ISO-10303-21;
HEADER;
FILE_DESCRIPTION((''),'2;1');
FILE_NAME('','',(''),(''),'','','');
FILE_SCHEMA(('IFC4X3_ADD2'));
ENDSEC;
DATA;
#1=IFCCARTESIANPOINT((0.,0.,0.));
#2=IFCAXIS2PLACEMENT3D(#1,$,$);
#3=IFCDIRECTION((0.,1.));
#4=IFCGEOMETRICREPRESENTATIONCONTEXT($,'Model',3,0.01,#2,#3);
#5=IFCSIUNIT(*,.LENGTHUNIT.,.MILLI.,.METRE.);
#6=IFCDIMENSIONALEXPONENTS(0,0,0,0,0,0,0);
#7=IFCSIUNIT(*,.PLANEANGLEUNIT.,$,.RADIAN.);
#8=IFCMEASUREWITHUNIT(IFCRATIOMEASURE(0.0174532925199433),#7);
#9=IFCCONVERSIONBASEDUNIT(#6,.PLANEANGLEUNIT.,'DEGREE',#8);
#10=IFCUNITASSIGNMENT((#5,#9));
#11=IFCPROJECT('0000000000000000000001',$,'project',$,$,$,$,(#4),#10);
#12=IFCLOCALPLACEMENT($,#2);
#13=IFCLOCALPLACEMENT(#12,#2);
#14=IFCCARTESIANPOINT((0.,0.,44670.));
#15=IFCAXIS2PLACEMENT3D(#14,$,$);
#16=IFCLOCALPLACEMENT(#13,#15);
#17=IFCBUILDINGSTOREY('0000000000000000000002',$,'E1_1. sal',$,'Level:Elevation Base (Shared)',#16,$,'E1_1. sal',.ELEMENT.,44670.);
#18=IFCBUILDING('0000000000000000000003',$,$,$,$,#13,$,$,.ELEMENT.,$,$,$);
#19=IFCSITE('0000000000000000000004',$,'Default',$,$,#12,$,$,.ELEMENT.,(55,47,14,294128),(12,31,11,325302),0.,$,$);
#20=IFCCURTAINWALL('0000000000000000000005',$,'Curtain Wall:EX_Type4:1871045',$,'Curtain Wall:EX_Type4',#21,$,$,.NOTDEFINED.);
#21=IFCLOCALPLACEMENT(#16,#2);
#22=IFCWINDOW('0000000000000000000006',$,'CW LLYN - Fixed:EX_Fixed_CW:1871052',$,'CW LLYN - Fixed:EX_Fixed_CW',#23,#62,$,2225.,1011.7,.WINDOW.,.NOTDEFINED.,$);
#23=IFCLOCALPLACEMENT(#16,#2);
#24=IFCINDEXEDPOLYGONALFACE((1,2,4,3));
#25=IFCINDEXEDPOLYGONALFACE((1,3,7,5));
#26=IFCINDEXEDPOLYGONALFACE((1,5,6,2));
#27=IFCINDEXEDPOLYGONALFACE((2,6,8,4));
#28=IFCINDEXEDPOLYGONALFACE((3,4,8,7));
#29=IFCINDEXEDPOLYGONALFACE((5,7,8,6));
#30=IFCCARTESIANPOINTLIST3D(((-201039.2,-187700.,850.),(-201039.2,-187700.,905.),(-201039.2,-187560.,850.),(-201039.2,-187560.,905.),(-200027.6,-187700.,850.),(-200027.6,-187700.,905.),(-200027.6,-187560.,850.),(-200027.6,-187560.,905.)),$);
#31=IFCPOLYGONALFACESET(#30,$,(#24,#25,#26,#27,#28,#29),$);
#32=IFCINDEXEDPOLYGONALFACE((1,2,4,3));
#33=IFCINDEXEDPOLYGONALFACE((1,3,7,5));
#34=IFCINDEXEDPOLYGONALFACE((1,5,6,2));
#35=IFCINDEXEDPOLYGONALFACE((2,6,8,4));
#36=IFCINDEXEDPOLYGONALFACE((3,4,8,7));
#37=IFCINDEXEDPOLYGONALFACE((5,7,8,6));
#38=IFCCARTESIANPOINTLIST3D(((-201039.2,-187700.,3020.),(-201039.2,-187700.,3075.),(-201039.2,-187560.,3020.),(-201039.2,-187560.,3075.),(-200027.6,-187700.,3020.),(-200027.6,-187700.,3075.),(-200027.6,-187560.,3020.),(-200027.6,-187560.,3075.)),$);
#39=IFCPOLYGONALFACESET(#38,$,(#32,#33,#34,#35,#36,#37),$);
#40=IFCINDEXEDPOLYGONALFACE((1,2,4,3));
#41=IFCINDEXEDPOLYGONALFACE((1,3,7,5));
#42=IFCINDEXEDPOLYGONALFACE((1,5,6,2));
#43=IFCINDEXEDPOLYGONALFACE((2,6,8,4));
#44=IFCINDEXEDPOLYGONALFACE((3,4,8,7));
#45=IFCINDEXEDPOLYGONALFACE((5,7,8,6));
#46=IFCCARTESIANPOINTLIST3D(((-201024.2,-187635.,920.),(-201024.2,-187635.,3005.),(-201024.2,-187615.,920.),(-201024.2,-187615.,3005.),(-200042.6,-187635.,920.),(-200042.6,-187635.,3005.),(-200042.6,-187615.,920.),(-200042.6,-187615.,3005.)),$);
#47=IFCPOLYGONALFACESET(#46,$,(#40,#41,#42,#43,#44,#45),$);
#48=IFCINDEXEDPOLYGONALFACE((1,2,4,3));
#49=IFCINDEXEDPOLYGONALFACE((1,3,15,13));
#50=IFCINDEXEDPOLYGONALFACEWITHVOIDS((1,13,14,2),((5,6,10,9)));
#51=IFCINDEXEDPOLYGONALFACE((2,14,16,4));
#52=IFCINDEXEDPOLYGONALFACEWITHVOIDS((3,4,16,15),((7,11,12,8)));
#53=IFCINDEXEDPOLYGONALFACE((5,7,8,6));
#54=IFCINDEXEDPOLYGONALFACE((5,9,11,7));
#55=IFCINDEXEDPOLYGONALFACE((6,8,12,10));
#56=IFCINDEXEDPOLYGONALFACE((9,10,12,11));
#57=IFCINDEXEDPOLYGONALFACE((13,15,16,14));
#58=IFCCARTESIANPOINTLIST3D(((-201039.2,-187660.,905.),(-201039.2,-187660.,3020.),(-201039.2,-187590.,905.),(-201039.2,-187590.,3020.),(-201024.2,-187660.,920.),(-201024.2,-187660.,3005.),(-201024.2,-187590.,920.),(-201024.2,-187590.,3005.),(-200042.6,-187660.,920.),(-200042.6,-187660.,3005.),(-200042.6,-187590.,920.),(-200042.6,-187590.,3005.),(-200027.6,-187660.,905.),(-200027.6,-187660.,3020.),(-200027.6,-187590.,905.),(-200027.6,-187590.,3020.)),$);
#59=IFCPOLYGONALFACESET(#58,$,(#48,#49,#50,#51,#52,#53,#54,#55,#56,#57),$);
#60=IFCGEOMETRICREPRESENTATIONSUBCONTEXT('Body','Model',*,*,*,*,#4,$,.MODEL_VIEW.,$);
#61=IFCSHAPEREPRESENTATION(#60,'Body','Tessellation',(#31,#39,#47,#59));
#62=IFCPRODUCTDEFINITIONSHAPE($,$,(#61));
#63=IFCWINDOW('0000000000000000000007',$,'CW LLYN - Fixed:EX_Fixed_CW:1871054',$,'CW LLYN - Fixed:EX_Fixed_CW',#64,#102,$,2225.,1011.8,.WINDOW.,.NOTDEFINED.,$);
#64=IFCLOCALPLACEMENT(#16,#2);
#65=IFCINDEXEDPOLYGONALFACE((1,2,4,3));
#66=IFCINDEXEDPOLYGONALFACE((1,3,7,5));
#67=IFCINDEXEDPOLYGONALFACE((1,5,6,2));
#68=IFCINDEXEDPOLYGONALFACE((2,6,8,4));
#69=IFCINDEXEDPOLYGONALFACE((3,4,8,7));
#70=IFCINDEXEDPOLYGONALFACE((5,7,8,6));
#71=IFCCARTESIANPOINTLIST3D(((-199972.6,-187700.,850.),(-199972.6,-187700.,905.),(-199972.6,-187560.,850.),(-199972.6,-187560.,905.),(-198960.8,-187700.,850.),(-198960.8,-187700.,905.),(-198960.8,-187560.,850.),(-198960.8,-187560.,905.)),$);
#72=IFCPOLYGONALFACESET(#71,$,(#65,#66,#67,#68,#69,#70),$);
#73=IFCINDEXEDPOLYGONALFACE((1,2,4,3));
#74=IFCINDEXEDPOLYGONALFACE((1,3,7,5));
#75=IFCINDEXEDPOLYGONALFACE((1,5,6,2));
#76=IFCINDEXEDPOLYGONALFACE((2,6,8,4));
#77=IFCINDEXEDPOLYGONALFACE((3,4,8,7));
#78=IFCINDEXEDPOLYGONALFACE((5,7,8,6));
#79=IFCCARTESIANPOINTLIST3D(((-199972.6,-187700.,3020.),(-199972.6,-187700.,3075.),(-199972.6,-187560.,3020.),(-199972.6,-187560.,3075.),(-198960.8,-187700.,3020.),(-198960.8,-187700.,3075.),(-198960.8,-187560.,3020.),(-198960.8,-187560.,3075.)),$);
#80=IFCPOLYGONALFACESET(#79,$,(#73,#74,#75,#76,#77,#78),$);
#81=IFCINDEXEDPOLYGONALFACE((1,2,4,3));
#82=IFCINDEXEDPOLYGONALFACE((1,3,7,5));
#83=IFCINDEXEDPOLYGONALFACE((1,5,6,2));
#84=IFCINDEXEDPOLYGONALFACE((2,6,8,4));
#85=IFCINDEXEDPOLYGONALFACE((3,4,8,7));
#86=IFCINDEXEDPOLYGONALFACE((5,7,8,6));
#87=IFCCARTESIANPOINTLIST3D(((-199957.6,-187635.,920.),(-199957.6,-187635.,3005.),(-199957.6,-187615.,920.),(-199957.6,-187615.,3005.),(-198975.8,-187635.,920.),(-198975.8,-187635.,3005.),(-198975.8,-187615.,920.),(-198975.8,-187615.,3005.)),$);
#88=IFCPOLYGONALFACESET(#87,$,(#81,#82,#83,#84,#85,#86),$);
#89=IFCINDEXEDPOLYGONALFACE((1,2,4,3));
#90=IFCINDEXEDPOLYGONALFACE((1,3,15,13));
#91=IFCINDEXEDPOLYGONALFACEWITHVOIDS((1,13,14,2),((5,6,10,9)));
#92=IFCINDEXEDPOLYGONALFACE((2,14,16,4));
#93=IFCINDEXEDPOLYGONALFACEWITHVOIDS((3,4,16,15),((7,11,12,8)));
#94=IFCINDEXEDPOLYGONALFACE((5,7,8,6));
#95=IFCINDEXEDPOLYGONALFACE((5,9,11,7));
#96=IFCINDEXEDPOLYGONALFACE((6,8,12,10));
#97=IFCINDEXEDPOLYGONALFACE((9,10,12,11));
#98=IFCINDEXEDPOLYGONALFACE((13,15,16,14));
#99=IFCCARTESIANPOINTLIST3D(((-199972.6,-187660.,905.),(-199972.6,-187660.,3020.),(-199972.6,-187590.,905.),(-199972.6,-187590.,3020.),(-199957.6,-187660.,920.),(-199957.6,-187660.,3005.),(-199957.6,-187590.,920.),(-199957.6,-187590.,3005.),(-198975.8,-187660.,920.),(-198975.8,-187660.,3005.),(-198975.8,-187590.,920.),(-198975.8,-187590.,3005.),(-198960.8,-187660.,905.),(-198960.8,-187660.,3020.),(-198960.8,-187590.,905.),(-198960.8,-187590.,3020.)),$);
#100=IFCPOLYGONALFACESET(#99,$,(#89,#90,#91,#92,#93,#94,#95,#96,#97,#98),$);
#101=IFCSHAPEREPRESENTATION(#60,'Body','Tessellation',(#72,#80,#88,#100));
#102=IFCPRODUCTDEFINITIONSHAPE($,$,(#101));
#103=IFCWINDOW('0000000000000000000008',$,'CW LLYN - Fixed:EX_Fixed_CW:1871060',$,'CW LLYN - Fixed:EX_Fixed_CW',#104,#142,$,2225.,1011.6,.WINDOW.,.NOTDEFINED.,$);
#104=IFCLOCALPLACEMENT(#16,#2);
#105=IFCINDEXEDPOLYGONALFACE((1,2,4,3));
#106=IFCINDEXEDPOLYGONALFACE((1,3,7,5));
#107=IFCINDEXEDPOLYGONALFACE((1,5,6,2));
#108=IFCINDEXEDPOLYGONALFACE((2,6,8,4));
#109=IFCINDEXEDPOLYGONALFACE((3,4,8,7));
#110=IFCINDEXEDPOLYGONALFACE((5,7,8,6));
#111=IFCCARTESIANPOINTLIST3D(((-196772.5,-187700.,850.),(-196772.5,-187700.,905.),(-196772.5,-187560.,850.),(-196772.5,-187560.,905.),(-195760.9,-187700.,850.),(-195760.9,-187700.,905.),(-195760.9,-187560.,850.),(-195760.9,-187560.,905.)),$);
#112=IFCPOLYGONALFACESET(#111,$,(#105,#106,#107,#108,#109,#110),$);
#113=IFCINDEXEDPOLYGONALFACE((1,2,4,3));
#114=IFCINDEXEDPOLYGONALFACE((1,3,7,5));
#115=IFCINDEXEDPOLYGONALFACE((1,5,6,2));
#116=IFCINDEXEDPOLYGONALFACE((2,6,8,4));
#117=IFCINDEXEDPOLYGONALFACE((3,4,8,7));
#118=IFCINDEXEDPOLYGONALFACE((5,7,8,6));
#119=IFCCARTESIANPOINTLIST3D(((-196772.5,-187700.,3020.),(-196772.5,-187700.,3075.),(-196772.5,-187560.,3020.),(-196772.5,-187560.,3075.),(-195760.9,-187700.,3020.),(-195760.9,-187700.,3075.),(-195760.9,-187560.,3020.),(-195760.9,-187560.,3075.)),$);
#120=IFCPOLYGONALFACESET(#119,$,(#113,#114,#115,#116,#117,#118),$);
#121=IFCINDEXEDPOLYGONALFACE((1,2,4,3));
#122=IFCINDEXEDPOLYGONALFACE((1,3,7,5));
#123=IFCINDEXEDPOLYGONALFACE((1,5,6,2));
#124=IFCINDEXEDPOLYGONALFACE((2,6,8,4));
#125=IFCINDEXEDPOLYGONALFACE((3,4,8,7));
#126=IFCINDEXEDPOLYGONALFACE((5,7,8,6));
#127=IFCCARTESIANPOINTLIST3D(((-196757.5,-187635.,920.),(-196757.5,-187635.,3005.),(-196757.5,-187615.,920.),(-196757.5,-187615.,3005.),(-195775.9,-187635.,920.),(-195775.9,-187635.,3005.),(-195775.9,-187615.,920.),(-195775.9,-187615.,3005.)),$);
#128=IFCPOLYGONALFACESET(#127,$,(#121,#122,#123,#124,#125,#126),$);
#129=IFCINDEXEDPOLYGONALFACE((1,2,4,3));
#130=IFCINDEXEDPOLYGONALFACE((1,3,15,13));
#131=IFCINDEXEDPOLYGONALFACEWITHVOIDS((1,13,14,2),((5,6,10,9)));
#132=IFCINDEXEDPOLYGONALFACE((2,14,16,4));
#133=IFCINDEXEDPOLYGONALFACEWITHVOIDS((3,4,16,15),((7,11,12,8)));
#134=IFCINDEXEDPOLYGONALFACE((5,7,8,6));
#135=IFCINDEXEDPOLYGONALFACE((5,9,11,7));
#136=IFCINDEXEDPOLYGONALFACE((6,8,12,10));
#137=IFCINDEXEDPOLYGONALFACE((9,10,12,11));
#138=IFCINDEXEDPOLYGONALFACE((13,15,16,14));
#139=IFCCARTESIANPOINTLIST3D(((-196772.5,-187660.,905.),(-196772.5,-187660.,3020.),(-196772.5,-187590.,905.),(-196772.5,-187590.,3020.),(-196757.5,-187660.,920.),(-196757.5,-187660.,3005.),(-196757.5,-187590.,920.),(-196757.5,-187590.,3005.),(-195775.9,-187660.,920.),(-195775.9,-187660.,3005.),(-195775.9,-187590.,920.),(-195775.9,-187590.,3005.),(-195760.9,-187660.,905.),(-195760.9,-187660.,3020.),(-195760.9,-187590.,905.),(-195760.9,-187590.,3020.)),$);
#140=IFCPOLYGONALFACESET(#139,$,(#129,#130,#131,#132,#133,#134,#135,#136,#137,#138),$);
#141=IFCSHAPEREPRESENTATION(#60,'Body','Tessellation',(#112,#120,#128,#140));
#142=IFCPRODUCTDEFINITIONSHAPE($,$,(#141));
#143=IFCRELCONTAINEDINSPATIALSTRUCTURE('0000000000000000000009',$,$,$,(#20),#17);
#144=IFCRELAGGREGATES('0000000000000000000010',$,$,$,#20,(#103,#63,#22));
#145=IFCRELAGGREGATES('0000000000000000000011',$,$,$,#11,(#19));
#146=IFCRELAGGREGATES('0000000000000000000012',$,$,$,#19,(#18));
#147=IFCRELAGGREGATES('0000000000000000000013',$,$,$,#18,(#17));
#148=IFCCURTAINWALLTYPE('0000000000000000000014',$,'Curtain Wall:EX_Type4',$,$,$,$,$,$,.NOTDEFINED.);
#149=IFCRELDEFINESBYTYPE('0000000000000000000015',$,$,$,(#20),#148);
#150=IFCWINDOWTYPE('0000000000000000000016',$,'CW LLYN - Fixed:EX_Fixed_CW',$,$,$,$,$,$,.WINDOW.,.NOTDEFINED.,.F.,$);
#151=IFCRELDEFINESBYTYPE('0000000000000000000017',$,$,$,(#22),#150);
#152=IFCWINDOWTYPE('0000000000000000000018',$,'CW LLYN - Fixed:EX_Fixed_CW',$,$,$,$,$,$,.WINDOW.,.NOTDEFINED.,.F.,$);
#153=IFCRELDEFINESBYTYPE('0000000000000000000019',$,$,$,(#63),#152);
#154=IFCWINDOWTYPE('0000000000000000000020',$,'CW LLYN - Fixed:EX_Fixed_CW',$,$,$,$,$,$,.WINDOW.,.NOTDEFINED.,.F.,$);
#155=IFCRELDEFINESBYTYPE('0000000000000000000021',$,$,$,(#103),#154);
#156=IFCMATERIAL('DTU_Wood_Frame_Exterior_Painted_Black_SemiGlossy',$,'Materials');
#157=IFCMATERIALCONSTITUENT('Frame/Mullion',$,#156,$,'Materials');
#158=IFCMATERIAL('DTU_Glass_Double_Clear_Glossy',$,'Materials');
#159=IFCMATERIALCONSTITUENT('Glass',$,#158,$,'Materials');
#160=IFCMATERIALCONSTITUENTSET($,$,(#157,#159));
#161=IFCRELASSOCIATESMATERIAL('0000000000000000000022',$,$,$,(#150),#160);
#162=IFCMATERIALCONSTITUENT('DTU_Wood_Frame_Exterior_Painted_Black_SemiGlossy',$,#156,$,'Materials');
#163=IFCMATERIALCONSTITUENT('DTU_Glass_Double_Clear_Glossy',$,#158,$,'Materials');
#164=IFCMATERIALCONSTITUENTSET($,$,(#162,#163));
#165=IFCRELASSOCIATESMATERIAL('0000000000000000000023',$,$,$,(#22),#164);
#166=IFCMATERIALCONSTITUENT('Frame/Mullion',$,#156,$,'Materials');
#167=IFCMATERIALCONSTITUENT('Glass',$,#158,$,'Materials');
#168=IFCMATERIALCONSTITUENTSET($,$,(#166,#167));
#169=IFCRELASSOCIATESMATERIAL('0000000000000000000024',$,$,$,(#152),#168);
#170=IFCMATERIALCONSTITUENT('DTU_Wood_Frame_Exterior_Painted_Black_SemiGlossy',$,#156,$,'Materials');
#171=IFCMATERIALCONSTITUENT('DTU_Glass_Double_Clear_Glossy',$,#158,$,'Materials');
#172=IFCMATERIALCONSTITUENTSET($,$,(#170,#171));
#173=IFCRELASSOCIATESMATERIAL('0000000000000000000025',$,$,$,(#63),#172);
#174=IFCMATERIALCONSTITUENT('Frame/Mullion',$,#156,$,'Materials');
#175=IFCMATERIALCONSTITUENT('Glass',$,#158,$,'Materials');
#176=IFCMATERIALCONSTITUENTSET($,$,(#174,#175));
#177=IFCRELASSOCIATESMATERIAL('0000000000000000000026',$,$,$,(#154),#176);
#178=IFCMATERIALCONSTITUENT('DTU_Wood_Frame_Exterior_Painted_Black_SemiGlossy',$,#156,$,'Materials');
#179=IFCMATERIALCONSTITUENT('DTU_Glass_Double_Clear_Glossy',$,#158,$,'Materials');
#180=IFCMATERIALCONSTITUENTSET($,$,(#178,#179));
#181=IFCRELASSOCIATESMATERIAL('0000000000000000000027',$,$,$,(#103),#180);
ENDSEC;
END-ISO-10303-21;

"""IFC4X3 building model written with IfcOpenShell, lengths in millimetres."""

from ifc_helpers import new_model, entity, si_unit, converted_unit, direction, frame, frame_2d, origin, origin_2d_with_axis, place, context, subcontext, project, spatial, polyline, rectangle, outline, extrude, source, transform, mapped, material, constituent, constituent_set, type_object, type_shapes, element, aggregate, save


model = new_model("IFC4X3")

# Units and contexts
model_context = context("Model", 3, precision=0.01, world=origin(), true_north=direction((0.0, 1.0)))
body_context = subcontext(model_context, "Body", "Model", "MODEL_VIEW")
ifc_project = project(units=[si_unit("LENGTHUNIT", "METRE", prefix="MILLI"), converted_unit("PLANEANGLEUNIT", "DEGREE", entity("IfcRatioMeasure", 0.0174532925199433), si_unit("PLANEANGLEUNIT", "RADIAN"), dimensions=[0, 0, 0, 0, 0, 0, 0])], contexts=[model_context])

# Site, building, storey
site_placement = place(None, origin())
site = spatial("IfcSite", under=ifc_project, at=site_placement, Name="Default", CompositionType="ELEMENT", RefLatitude=(55, 47, 14, 294128), RefLongitude=(12, 31, 11, 325302), RefElevation=0.0)
building_placement = place(site_placement, origin())
building = spatial("IfcBuilding", under=site, at=building_placement, CompositionType="ELEMENT")
storey_placement = place(building_placement, frame((0.0, 0.0, 44670.0)))
storey = spatial("IfcBuildingStorey", under=building, at=storey_placement, Name="E1_1. sal", ObjectType="Level:Elevation Base (Shared)", LongName="E1_1. sal", CompositionType="ELEMENT", Elevation=44670.0)

# Curtain wall
curtain_wall_type_1 = type_object("IfcCurtainWallType", Name="Curtain Wall:EX_Type4", PredefinedType="NOTDEFINED")
curtain_wall_1_placement = place(storey_placement, frame((0.0, 0.0, -44670.0)))
curtain_wall_1 = element("IfcCurtainWall", 1, at=curtain_wall_1_placement, inside=storey, type_object=curtain_wall_type_1, Name="Curtain Wall:EX_Type4:1871045", ObjectType="Curtain Wall:EX_Type4", PredefinedType="NOTDEFINED")

# Windows
ifc_material_1 = material(Name="DTU_Wood_Frame_Exterior_Painted_Black_SemiGlossy", Category="Materials")
ifc_material_2 = material(Name="DTU_Glass_Double_Clear_Glossy", Category="Materials")
ifc_constituent_1 = constituent(ifc_material_1, Name="DTU_Wood_Frame_Exterior_Painted_Black_SemiGlossy", Category="Materials")
ifc_constituent_2 = constituent(ifc_material_2, Name="DTU_Glass_Double_Clear_Glossy", Category="Materials")
ifc_constituent_set_1 = constituent_set(constituents=[ifc_constituent_1, ifc_constituent_2])
ifc_constituent_3 = constituent(ifc_material_1, Name="Frame/Mullion", Category="Materials")
ifc_constituent_4 = constituent(ifc_material_2, Name="Glass", Category="Materials")
ifc_constituent_set_2 = constituent_set(constituents=[ifc_constituent_3, ifc_constituent_4])
window_type_1 = type_object("IfcWindowType", Name="CW LLYN - Fixed:EX_Fixed_CW", ParameterTakesPrecedence=False, PartitioningType="NOTDEFINED", PredefinedType="WINDOW", material=ifc_constituent_set_2)
shared_shape_1 = source(origin(), body_context, "Body", "SweptSolid", [
    extrude(rectangle(XDim=140.0, YDim=1011.7, at=origin_2d_with_axis()), frame((0.0, -130.0, 0.0), z_axis=(0.0, 0.0, 1.0), x_axis=(0.0, -1.0, 0.0)), (0.0, 0.0, 1.0), 55.0),
    extrude(rectangle(XDim=140.0, YDim=1011.7, at=frame_2d((0.0, 0.0), x_axis=(1.0, 0.0))), frame((0.0, -130.0, 2170.0), z_axis=(0.0, 0.0, 1.0), x_axis=(0.0, -1.0, 0.0)), (0.0, 0.0, 1.0), 55.0),
    extrude(rectangle(XDim=981.7, YDim=20.0, at=frame_2d((0.0, 0.0), x_axis=(1.0, 0.0))), frame((0.0, -125.0, 70.0), z_axis=(0.0, 0.0, 1.0), x_axis=(-1.0, 0.0, 0.0)), (0.0, 0.0, 1.0), 2085.0),
    extrude(outline(polyline([(-1057.5, -505.8), (1057.5, -505.8), (1057.5, 505.8), (-1057.5, 505.8), (-1057.5, -505.8)]), holes=[polyline([(-1042.5, 490.8), (1042.5, 490.8), (1042.5, -490.8), (-1042.5, -490.8), (-1042.5, 490.8)])]), frame((0.0, -90.0, 1112.5), z_axis=(0.0, -1.0, 0.0), x_axis=(0.0, 0.0, 1.0)), (0.0, 0.0, 1.0), 70.0),
])
type_shapes(window_type_1, [shared_shape_1])
window_1_placement = place(curtain_wall_1_placement, frame((-200533.4, -187500.0, 45520.0)))
window_1 = element("IfcWindow", 2, at=window_1_placement, type_object=window_type_1, material=ifc_constituent_set_1, Name="CW LLYN - Fixed:EX_Fixed_CW:1871052", ObjectType="CW LLYN - Fixed:EX_Fixed_CW", OverallHeight=2225.0, OverallWidth=1011.7, PartitioningType="NOTDEFINED", PredefinedType="WINDOW", context=body_context, shape_type="MappedRepresentation", body=[
    mapped(shared_shape_1, transform((0.0, 0.0, 0.0), scale=1.0)),
])
ifc_constituent_5 = constituent(ifc_material_1, Name="DTU_Wood_Frame_Exterior_Painted_Black_SemiGlossy", Category="Materials")
ifc_constituent_6 = constituent(ifc_material_2, Name="DTU_Glass_Double_Clear_Glossy", Category="Materials")
ifc_constituent_set_3 = constituent_set(constituents=[ifc_constituent_5, ifc_constituent_6])
ifc_constituent_7 = constituent(ifc_material_1, Name="Frame/Mullion", Category="Materials")
ifc_constituent_8 = constituent(ifc_material_2, Name="Glass", Category="Materials")
ifc_constituent_set_4 = constituent_set(constituents=[ifc_constituent_7, ifc_constituent_8])
window_type_2 = type_object("IfcWindowType", Name="CW LLYN - Fixed:EX_Fixed_CW", ParameterTakesPrecedence=False, PartitioningType="NOTDEFINED", PredefinedType="WINDOW", material=ifc_constituent_set_4)
shared_shape_2 = source(origin(), body_context, "Body", "SweptSolid", [
    extrude(rectangle(XDim=140.0, YDim=1011.8, at=origin_2d_with_axis()), frame((0.0, -130.0, 0.0), z_axis=(0.0, 0.0, 1.0), x_axis=(0.0, -1.0, 0.0)), (0.0, 0.0, 1.0), 55.0),
    extrude(rectangle(XDim=140.0, YDim=1011.8, at=frame_2d((0.0, 0.0), x_axis=(1.0, 0.0))), frame((0.0, -130.0, 2170.0), z_axis=(0.0, 0.0, 1.0), x_axis=(0.0, -1.0, 0.0)), (0.0, 0.0, 1.0), 55.0),
    extrude(rectangle(XDim=981.8, YDim=20.0, at=frame_2d((0.0, 0.0), x_axis=(1.0, 0.0))), frame((0.0, -125.0, 70.0), z_axis=(0.0, 0.0, 1.0), x_axis=(-1.0, 0.0, 0.0)), (0.0, 0.0, 1.0), 2085.0),
    extrude(outline(polyline([(-1057.5, -505.9), (1057.5, -505.9), (1057.5, 505.9), (-1057.5, 505.9), (-1057.5, -505.9)]), holes=[polyline([(-1042.5, 490.9), (1042.5, 490.9), (1042.5, -490.9), (-1042.5, -490.9), (-1042.5, 490.9)])]), frame((0.0, -90.0, 1112.5), z_axis=(0.0, -1.0, 0.0), x_axis=(0.0, 0.0, 1.0)), (0.0, 0.0, 1.0), 70.0),
])
type_shapes(window_type_2, [shared_shape_2])
window_2_placement = place(curtain_wall_1_placement, frame((-199466.7, -187500.0, 45520.0)))
window_2 = element("IfcWindow", 3, at=window_2_placement, type_object=window_type_2, material=ifc_constituent_set_3, Name="CW LLYN - Fixed:EX_Fixed_CW:1871054", ObjectType="CW LLYN - Fixed:EX_Fixed_CW", OverallHeight=2225.0, OverallWidth=1011.8, PartitioningType="NOTDEFINED", PredefinedType="WINDOW", context=body_context, shape_type="MappedRepresentation", body=[
    mapped(shared_shape_2, transform((0.0, 0.0, 0.0), scale=1.0)),
])
ifc_constituent_9 = constituent(ifc_material_1, Name="DTU_Wood_Frame_Exterior_Painted_Black_SemiGlossy", Category="Materials")
ifc_constituent_10 = constituent(ifc_material_2, Name="DTU_Glass_Double_Clear_Glossy", Category="Materials")
ifc_constituent_set_5 = constituent_set(constituents=[ifc_constituent_9, ifc_constituent_10])
ifc_constituent_11 = constituent(ifc_material_1, Name="Frame/Mullion", Category="Materials")
ifc_constituent_12 = constituent(ifc_material_2, Name="Glass", Category="Materials")
ifc_constituent_set_6 = constituent_set(constituents=[ifc_constituent_11, ifc_constituent_12])
window_type_3 = type_object("IfcWindowType", Name="CW LLYN - Fixed:EX_Fixed_CW", ParameterTakesPrecedence=False, PartitioningType="NOTDEFINED", PredefinedType="WINDOW", material=ifc_constituent_set_6)
shared_shape_3 = source(origin(), body_context, "Body", "SweptSolid", [
    extrude(rectangle(XDim=140.0, YDim=1011.6, at=origin_2d_with_axis()), frame((0.0, -130.0, 0.0), z_axis=(0.0, 0.0, 1.0), x_axis=(0.0, -1.0, 0.0)), (0.0, 0.0, 1.0), 55.0),
    extrude(rectangle(XDim=140.0, YDim=1011.6, at=frame_2d((0.0, 0.0), x_axis=(1.0, 0.0))), frame((0.0, -130.0, 2170.0), z_axis=(0.0, 0.0, 1.0), x_axis=(0.0, -1.0, 0.0)), (0.0, 0.0, 1.0), 55.0),
    extrude(rectangle(XDim=981.6, YDim=20.0, at=frame_2d((0.0, 0.0), x_axis=(1.0, 0.0))), frame((0.0, -125.0, 70.0), z_axis=(0.0, 0.0, 1.0), x_axis=(-1.0, 0.0, 0.0)), (0.0, 0.0, 1.0), 2085.0),
    extrude(outline(polyline([(-1057.5, -505.8), (1057.5, -505.8), (1057.5, 505.8), (-1057.5, 505.8), (-1057.5, -505.8)]), holes=[polyline([(-1042.5, 490.8), (1042.5, 490.8), (1042.5, -490.8), (-1042.5, -490.8), (-1042.5, 490.8)])]), frame((0.0, -90.0, 1112.5), z_axis=(0.0, -1.0, 0.0), x_axis=(0.0, 0.0, 1.0)), (0.0, 0.0, 1.0), 70.0),
])
type_shapes(window_type_3, [shared_shape_3])
window_3_placement = place(curtain_wall_1_placement, frame((-196266.7, -187500.0, 45520.0)))
window_3 = element("IfcWindow", 4, at=window_3_placement, type_object=window_type_3, material=ifc_constituent_set_5, Name="CW LLYN - Fixed:EX_Fixed_CW:1871060", ObjectType="CW LLYN - Fixed:EX_Fixed_CW", OverallHeight=2225.0, OverallWidth=1011.6, PartitioningType="NOTDEFINED", PredefinedType="WINDOW", context=body_context, shape_type="MappedRepresentation", body=[
    mapped(shared_shape_3, transform((0.0, 0.0, 0.0), scale=1.0)),
])

aggregate(curtain_wall_1, [window_3, window_2, window_1])

save(model, "model.ifc")
